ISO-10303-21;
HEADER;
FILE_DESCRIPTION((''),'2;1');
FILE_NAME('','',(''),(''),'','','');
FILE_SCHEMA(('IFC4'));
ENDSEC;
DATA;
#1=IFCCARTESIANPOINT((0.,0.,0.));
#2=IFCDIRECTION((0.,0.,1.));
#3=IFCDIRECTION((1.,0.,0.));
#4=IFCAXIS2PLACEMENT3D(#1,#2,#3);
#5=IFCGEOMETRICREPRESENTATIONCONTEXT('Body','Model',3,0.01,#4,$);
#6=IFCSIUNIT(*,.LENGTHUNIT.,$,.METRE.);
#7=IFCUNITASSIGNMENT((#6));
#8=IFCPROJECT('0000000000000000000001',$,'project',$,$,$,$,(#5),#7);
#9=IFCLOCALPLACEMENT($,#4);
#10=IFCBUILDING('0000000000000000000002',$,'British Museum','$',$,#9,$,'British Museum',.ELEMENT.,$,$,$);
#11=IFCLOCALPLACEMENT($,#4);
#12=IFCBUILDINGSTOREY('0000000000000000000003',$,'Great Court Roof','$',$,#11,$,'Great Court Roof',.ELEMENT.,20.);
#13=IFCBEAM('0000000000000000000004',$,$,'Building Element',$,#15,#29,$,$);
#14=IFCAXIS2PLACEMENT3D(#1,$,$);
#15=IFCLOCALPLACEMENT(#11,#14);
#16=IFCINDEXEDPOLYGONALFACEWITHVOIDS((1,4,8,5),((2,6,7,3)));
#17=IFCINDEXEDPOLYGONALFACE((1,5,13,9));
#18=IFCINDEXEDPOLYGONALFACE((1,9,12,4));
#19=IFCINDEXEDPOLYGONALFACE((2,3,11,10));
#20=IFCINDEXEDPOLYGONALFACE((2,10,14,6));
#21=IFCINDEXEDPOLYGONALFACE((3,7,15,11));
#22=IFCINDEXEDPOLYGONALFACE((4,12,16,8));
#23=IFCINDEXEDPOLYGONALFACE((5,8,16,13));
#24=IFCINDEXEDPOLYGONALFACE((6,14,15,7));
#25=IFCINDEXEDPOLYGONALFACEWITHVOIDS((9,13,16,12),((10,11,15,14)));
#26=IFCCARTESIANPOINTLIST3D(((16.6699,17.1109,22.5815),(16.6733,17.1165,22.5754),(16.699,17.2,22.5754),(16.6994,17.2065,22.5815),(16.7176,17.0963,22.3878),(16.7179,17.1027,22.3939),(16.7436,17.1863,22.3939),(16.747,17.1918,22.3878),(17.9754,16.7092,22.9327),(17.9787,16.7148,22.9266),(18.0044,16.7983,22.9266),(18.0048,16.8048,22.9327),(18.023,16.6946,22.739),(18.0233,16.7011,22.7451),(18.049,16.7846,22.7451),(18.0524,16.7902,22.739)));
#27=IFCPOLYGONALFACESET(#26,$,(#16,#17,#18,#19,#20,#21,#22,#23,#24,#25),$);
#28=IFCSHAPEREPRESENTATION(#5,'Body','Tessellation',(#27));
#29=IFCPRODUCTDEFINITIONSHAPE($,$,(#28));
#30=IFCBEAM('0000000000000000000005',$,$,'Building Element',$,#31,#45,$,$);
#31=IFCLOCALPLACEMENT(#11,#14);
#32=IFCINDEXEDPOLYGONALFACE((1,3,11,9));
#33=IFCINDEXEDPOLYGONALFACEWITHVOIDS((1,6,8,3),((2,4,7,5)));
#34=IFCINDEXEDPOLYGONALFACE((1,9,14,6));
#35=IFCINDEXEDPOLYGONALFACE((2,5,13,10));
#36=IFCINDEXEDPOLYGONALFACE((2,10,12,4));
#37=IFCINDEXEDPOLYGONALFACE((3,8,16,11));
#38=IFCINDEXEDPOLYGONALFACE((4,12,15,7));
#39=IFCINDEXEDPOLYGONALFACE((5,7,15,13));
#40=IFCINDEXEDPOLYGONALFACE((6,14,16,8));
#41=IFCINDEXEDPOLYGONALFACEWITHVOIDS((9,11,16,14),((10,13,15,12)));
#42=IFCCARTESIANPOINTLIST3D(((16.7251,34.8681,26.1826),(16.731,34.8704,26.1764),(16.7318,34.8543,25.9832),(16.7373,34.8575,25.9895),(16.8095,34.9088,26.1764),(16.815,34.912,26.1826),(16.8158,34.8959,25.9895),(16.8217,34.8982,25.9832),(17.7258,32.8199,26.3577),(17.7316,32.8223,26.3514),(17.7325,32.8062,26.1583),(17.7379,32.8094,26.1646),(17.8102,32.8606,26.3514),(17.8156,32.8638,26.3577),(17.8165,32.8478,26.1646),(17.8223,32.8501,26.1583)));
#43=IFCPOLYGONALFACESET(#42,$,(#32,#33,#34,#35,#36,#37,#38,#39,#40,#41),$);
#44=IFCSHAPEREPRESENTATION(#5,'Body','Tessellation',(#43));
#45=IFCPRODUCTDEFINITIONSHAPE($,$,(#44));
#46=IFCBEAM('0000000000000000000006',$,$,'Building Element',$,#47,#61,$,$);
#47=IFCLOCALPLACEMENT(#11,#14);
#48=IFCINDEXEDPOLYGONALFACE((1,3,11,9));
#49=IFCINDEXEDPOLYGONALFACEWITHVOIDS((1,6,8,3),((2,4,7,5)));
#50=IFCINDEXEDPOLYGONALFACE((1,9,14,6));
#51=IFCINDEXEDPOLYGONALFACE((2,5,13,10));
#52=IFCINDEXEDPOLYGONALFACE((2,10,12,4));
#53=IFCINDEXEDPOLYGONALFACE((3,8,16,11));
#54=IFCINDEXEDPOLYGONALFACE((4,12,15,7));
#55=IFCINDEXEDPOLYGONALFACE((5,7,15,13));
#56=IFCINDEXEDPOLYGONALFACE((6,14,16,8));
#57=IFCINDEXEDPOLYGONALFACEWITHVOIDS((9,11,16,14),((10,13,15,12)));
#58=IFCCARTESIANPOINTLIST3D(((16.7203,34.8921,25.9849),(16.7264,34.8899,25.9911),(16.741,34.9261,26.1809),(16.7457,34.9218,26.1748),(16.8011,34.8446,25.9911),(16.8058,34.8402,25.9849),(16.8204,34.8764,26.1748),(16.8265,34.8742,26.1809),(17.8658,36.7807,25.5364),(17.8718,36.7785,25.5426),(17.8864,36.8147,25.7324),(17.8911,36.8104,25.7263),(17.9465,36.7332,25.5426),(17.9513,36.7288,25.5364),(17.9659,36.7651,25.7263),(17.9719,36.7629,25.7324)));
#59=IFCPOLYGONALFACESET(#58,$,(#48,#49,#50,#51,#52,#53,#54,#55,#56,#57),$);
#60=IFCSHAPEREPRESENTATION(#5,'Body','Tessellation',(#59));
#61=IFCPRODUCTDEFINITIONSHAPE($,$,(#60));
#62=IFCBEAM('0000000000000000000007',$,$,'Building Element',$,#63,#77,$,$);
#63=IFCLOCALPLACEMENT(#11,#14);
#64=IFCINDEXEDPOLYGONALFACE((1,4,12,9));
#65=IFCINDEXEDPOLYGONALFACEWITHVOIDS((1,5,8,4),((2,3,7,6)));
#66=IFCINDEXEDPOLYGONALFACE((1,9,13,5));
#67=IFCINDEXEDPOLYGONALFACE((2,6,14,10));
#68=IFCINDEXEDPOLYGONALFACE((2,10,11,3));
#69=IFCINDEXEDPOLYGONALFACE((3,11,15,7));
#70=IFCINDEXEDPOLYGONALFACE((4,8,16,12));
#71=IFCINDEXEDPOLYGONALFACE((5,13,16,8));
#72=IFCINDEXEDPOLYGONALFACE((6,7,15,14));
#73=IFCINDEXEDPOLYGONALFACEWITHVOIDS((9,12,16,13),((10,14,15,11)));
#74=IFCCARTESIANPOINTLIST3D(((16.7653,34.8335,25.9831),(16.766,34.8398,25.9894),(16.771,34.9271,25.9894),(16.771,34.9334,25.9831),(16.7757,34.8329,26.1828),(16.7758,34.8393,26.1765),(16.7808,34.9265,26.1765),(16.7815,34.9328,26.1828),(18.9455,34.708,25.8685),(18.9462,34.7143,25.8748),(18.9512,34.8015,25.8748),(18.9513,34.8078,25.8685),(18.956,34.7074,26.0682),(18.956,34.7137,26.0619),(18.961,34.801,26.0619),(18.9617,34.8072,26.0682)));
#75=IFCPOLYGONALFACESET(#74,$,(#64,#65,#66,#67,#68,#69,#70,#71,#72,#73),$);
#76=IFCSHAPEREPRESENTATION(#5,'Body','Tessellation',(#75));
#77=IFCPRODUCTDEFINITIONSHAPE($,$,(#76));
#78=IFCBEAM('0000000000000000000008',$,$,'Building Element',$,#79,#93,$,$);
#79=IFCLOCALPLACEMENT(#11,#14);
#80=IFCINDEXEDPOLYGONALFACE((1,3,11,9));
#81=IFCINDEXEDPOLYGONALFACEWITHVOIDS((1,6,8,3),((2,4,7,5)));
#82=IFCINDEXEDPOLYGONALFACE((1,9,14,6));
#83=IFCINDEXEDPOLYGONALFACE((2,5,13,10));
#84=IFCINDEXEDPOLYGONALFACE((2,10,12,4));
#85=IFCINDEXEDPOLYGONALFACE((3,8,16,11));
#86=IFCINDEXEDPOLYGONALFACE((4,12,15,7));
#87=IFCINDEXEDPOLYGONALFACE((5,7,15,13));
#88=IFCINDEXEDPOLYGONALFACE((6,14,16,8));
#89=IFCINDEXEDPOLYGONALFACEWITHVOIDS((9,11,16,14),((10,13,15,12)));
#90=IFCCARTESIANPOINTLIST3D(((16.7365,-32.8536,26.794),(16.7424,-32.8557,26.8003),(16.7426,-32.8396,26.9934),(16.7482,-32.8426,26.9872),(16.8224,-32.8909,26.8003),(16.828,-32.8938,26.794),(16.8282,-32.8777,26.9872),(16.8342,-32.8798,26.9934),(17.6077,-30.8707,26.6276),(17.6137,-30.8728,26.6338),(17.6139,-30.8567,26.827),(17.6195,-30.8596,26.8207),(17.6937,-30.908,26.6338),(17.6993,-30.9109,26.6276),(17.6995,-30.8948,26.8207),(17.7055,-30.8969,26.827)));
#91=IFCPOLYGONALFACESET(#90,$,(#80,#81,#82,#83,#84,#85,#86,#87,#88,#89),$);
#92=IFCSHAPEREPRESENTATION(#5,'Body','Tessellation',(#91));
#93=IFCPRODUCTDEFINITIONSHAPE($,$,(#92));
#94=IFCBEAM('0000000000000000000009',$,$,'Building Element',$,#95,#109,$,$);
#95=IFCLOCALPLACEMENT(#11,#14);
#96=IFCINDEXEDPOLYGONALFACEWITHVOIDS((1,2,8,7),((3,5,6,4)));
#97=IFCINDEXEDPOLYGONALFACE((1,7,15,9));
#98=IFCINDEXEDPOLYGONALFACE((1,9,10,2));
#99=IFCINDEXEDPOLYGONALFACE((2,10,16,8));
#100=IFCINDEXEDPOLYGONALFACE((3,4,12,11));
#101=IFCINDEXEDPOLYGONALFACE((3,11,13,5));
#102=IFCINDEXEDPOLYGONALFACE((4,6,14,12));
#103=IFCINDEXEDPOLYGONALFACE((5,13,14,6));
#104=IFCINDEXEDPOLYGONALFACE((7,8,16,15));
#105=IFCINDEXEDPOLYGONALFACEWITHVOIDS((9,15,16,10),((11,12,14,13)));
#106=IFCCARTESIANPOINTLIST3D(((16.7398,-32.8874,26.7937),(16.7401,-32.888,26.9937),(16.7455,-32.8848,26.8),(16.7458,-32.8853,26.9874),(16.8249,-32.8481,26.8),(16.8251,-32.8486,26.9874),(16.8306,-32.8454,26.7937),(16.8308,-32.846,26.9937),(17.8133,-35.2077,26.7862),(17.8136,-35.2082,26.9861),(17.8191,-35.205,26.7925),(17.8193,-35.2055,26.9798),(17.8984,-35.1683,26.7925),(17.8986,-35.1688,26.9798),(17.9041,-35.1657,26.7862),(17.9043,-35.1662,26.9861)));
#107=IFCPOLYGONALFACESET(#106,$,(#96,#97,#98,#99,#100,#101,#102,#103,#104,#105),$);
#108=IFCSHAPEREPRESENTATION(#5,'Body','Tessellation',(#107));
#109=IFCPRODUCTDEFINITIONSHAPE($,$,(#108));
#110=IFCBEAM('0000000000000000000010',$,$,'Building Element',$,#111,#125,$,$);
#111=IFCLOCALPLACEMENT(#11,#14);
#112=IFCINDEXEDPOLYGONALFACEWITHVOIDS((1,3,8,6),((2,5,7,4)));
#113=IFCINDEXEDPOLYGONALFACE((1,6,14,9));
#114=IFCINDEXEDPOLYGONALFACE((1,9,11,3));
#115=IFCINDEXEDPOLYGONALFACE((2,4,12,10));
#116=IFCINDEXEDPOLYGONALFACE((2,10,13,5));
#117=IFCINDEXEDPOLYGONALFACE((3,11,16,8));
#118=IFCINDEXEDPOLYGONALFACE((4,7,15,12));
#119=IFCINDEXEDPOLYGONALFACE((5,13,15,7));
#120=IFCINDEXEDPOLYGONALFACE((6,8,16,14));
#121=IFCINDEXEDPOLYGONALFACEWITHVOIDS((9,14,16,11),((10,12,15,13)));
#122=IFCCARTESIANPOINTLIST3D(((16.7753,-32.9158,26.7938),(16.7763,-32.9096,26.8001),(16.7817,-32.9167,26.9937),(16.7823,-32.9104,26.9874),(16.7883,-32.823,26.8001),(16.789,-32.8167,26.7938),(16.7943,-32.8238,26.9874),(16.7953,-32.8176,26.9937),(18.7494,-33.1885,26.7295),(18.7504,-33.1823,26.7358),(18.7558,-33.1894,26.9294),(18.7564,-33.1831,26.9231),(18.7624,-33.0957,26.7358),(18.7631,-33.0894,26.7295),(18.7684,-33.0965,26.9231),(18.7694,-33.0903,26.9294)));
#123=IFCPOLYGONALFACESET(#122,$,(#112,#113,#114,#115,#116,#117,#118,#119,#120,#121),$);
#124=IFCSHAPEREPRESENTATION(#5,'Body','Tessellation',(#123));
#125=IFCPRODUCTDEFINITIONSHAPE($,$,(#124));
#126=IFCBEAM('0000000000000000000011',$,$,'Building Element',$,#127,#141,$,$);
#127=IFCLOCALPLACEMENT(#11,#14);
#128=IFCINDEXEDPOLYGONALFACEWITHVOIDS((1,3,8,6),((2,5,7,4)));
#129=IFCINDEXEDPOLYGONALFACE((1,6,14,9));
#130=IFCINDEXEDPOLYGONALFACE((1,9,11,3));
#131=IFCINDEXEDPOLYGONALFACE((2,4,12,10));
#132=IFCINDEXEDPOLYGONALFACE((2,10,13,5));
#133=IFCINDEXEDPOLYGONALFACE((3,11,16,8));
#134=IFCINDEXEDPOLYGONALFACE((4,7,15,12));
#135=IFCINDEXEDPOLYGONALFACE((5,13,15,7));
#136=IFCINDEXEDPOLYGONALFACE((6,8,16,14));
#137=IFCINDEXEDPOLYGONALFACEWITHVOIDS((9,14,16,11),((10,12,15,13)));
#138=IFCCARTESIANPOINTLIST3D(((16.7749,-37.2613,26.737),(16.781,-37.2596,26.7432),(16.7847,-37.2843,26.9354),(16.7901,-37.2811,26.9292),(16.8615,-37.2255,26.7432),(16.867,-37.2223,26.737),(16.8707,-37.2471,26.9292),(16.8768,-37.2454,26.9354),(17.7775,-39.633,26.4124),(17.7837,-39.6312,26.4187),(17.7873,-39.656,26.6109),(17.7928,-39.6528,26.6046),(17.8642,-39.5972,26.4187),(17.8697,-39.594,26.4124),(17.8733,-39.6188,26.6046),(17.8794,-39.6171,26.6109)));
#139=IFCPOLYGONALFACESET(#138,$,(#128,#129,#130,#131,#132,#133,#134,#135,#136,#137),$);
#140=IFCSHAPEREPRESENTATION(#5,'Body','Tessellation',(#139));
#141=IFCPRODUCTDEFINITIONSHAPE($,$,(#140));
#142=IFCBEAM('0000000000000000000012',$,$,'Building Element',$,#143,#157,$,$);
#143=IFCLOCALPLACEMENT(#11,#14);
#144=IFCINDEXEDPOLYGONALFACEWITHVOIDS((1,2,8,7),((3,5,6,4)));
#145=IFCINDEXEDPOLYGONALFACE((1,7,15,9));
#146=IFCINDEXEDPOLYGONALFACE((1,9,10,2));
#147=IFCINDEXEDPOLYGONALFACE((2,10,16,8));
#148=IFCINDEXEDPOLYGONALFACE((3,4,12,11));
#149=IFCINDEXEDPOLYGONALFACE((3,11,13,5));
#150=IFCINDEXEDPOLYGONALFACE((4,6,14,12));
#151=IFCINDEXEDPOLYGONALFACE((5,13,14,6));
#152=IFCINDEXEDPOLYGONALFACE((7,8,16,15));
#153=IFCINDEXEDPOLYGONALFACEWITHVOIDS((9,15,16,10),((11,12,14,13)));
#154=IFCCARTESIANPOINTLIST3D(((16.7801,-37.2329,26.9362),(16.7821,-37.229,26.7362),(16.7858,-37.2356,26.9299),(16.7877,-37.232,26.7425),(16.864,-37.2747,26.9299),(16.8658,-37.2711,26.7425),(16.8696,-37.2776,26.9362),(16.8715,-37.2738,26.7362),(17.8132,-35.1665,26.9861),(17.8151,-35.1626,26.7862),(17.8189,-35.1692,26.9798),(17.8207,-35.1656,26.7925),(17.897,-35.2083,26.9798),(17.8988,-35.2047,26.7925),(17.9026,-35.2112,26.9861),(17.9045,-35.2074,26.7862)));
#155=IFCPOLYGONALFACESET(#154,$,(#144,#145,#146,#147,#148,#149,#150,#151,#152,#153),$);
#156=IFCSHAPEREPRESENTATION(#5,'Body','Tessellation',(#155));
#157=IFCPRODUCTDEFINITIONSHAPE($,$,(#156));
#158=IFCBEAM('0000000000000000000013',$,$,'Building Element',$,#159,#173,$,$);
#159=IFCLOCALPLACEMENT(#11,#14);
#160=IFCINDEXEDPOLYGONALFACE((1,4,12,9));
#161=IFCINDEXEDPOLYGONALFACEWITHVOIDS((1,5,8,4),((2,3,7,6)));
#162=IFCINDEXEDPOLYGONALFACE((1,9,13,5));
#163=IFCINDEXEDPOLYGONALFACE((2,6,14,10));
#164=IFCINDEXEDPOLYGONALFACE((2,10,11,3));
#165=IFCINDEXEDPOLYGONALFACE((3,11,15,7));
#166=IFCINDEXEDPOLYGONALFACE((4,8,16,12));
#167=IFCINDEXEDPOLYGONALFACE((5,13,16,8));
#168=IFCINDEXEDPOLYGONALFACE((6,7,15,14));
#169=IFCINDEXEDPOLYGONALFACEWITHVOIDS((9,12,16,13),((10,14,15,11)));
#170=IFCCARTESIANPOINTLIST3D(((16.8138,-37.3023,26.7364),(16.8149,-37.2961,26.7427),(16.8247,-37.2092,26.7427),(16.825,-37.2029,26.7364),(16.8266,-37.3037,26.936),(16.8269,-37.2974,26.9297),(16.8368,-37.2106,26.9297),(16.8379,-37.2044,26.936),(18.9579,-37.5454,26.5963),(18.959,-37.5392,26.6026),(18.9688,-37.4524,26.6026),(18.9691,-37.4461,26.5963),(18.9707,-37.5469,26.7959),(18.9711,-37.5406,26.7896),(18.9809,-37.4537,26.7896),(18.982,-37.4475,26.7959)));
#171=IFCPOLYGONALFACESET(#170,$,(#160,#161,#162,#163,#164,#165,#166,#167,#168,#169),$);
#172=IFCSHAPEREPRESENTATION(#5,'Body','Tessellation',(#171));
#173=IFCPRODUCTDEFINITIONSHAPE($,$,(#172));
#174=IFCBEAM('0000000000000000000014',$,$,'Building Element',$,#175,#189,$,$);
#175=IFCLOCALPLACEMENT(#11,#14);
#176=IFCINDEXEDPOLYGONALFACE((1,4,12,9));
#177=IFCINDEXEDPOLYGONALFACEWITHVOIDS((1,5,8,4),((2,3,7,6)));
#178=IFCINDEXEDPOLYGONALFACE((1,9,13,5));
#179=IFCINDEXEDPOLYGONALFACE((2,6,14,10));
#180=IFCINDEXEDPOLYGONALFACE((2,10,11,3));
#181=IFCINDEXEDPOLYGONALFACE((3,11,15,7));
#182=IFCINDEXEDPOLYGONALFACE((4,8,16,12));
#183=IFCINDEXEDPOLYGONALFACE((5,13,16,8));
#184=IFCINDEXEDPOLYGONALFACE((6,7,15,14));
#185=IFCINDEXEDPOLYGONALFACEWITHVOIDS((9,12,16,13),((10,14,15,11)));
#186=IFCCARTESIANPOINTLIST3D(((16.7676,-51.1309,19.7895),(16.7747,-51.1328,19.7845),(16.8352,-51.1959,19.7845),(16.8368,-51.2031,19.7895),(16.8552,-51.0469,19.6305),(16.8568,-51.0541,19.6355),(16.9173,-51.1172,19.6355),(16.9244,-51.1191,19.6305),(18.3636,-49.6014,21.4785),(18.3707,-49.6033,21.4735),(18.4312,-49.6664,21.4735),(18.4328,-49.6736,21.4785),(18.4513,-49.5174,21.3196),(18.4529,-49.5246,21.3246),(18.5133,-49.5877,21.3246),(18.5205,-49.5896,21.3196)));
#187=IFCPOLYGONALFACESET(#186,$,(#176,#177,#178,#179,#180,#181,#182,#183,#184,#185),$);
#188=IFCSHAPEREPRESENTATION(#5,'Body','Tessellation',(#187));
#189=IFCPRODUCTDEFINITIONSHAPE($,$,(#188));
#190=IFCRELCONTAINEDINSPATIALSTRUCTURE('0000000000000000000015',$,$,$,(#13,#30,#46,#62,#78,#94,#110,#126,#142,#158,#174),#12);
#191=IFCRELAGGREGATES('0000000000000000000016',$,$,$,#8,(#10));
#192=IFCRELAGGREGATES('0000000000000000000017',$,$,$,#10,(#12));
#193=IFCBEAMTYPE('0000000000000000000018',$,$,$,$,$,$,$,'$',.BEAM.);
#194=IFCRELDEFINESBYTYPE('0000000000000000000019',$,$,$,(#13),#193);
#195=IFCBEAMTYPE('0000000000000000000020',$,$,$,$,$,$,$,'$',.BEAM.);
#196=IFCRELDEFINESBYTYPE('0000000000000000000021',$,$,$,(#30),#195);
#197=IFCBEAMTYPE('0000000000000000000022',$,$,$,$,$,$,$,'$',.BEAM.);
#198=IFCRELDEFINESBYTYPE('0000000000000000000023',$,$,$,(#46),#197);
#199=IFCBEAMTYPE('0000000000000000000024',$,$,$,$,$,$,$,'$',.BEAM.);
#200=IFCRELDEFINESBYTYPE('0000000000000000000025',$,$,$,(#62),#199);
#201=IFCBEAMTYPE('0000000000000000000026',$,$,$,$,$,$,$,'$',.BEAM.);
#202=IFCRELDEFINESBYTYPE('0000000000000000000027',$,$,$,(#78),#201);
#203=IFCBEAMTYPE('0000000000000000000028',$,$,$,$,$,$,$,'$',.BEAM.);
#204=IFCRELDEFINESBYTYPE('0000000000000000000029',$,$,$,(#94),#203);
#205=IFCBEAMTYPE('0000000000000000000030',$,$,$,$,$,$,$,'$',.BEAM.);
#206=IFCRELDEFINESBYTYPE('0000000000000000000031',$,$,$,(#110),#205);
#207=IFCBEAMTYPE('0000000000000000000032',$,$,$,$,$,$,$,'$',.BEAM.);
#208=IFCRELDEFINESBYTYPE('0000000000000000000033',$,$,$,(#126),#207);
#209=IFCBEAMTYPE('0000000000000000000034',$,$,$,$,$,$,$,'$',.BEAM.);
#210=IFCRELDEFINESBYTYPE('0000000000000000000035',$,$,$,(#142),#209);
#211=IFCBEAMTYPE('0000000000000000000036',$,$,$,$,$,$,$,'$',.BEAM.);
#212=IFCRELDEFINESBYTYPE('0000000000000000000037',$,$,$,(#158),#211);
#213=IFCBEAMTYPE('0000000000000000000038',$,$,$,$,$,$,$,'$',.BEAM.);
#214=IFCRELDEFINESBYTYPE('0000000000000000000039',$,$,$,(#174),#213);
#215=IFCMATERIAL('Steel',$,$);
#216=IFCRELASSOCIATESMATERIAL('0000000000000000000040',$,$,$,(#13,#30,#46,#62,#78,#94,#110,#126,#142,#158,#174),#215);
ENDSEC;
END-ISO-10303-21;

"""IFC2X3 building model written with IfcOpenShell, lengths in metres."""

from ifc_helpers import new_model, si_unit, frame, origin_with_axes, origin_2d, place, context, project, spatial, hollow_rectangle, extrude, material, type_object, element, save


model = new_model("IFC2X3")

# Units and contexts
model_context = context("Model", 3, precision=0.01, world=origin_with_axes(), identifier="Body")
ifc_project = project(units=[si_unit("LENGTHUNIT", "METRE")], contexts=[model_context])

# Building, storey
building_placement = place(None, origin_with_axes())
building = spatial("IfcBuilding", under=ifc_project, at=building_placement, Name="British Museum", Description="$", LongName="British Museum", CompositionType="ELEMENT")
storey_placement = place(None, origin_with_axes())
storey = spatial("IfcBuildingStorey", under=building, at=storey_placement, Name="Great Court Roof", Description="$", LongName="Great Court Roof", CompositionType="ELEMENT", Elevation=20.0)

# Beams
ifc_material = material(Name="Steel")
beam_type_1 = type_object("IfcBeamType", ElementType="$", PredefinedType="BEAM")
beam_1_placement = place(None, origin_with_axes())
element("IfcBeam", 1, at=beam_1_placement, inside=storey, type_object=beam_type_1, material=ifc_material, Description="Building Element", context=model_context, shape_type="SweptSolid", body=[
    extrude(hollow_rectangle(XDim=0.1, YDim=0.2, WallThickness=0.0063, InnerFilletRadius=-0.0063, OuterFilletRadius=0.0, at=origin_2d()), frame((16.7085, 17.1514, 22.4846), z_axis=(0.925668, -0.284824, 0.249025), x_axis=(0.294088, 0.955778, 0.0)), (0.0, 0.0, 1.0), 1.4103),
])
beam_type_2 = type_object("IfcBeamType", ElementType="$", PredefinedType="BEAM")
beam_2_placement = place(None, origin_with_axes())
element("IfcBeam", 2, at=beam_2_placement, inside=storey, type_object=beam_type_2, material=ifc_material, Description="Building Element", context=model_context, shape_type="SweptSolid", body=[
    extrude(hollow_rectangle(XDim=0.1, YDim=0.2, WallThickness=0.0063, InnerFilletRadius=-0.0063, OuterFilletRadius=0.0, at=origin_2d()), frame((16.7734, 34.8832, 26.0829), z_axis=(0.437693, -0.895858, 0.076573), x_axis=(0.898496, 0.438982, 0.0)), (0.0, 0.0, 1.0), 2.2862),
])
beam_type_3 = type_object("IfcBeamType", ElementType="$", PredefinedType="BEAM")
beam_3_placement = place(None, origin_with_axes())
element("IfcBeam", 3, at=beam_3_placement, inside=storey, type_object=beam_type_3, material=ifc_material, Description="Building Element", context=model_context, shape_type="SweptSolid", body=[
    extrude(hollow_rectangle(XDim=0.1, YDim=0.2, WallThickness=0.0063, InnerFilletRadius=-0.0063, OuterFilletRadius=0.0, at=origin_2d()), frame((16.7734, 34.8832, 26.0829), z_axis=(0.508208, 0.837933, -0.198982), x_axis=(-0.855031, 0.518578, 0.0)), (0.0, 0.0, 1.0), 2.2539),
])
beam_type_4 = type_object("IfcBeamType", ElementType="$", PredefinedType="BEAM")
beam_4_placement = place(None, origin_with_axes())
element("IfcBeam", 4, at=beam_4_placement, inside=storey, type_object=beam_type_4, material=ifc_material, Description="Building Element", context=model_context, shape_type="SweptSolid", body=[
    extrude(hollow_rectangle(XDim=0.1, YDim=0.2, WallThickness=0.0063, InnerFilletRadius=-0.0063, OuterFilletRadius=0.0, at=origin_2d()), frame((16.7734, 34.8832, 26.0829), z_axis=(0.996975, -0.057408, -0.052403), x_axis=(0.057487, 0.998346, 0.0)), (0.0, 0.0, 1.0), 2.1868),
])
beam_type_5 = type_object("IfcBeamType", ElementType="$", PredefinedType="BEAM")
beam_5_placement = place(None, origin_with_axes())
element("IfcBeam", 5, at=beam_5_placement, inside=storey, type_object=beam_type_5, material=ifc_material, Description="Building Element", context=model_context, shape_type="SweptSolid", body=[
    extrude(hollow_rectangle(XDim=0.1, YDim=0.2, WallThickness=0.0063, InnerFilletRadius=-0.0063, OuterFilletRadius=0.0, at=origin_2d()), frame((16.7853, -32.8667, 26.8937), z_axis=(0.401094, 0.912825, -0.076635), x_axis=(-0.915518, 0.402277, 0.0)), (0.0, 0.0, 1.0), 2.1723),
])
beam_type_6 = type_object("IfcBeamType", ElementType="$", PredefinedType="BEAM")
beam_6_placement = place(None, origin_with_axes())
element("IfcBeam", 6, at=beam_6_placement, inside=storey, type_object=beam_type_6, material=ifc_material, Description="Building Element", context=model_context, shape_type="SweptSolid", body=[
    extrude(hollow_rectangle(XDim=0.1, YDim=0.2, WallThickness=0.0063, InnerFilletRadius=-0.0063, OuterFilletRadius=0.0, at=origin_2d()), frame((16.7853, -32.8667, 26.8937), z_axis=(0.419916, -0.907558, -0.002966), x_axis=(0.907562, 0.419918, 0.0)), (0.0, 0.0, 1.0), 2.5565),
])
beam_type_7 = type_object("IfcBeamType", ElementType="$", PredefinedType="BEAM")
beam_7_placement = place(None, origin_with_axes())
element("IfcBeam", 7, at=beam_7_placement, inside=storey, type_object=beam_type_7, material=ifc_material, Description="Building Element", context=model_context, shape_type="SweptSolid", body=[
    extrude(hollow_rectangle(XDim=0.1, YDim=0.2, WallThickness=0.0063, InnerFilletRadius=-0.0063, OuterFilletRadius=0.0, at=origin_2d()), frame((16.7853, -32.8667, 26.8937), z_axis=(0.99008, -0.136758, -0.032229), x_axis=(0.136829, 0.990595, 0.0)), (0.0, 0.0, 1.0), 1.9939),
])
beam_type_8 = type_object("IfcBeamType", ElementType="$", PredefinedType="BEAM")
beam_8_placement = place(None, origin_with_axes())
element("IfcBeam", 8, at=beam_8_placement, inside=storey, type_object=beam_type_8, material=ifc_material, Description="Building Element", context=model_context, shape_type="SweptSolid", body=[
    extrude(hollow_rectangle(XDim=0.1, YDim=0.2, WallThickness=0.0063, InnerFilletRadius=-0.0063, OuterFilletRadius=0.0, at=origin_2d()), frame((16.8258, -37.2533, 26.8362), z_axis=(0.386328, -0.913845, -0.125048), x_axis=(0.921075, 0.389385, 0.0)), (0.0, 0.0, 1.0), 2.5953),
])
beam_type_9 = type_object("IfcBeamType", ElementType="$", PredefinedType="BEAM")
beam_9_placement = place(None, origin_with_axes())
element("IfcBeam", 9, at=beam_9_placement, inside=storey, type_object=beam_type_9, material=ifc_material, Description="Building Element", context=model_context, shape_type="SweptSolid", body=[
    extrude(hollow_rectangle(XDim=0.1, YDim=0.2, WallThickness=0.0063, InnerFilletRadius=-0.0063, OuterFilletRadius=0.0, at=origin_2d()), frame((16.8258, -37.2533, 26.8362), z_axis=(0.447042, 0.894252, 0.021619), x_axis=(-0.894461, 0.447146, 0.0)), (0.0, 0.0, 1.0), 2.3108),
])
beam_type_10 = type_object("IfcBeamType", ElementType="$", PredefinedType="BEAM")
beam_10_placement = place(None, origin_with_axes())
element("IfcBeam", 10, at=beam_10_placement, inside=storey, type_object=beam_type_10, material=ifc_material, Description="Building Element", context=model_context, shape_type="SweptSolid", body=[
    extrude(hollow_rectangle(XDim=0.1, YDim=0.2, WallThickness=0.0063, InnerFilletRadius=-0.0063, OuterFilletRadius=0.0, at=origin_2d()), frame((16.8258, -37.2533, 26.8362), z_axis=(0.991543, -0.112443, -0.064802), x_axis=(0.112679, 0.993631, 0.0)), (0.0, 0.0, 1.0), 2.1624),
])
beam_type_11 = type_object("IfcBeamType", ElementType="$", PredefinedType="BEAM")
beam_11_placement = place(None, origin_with_axes())
element("IfcBeam", 11, at=beam_11_placement, inside=storey, type_object=beam_type_11, material=ifc_material, Description="Building Element", context=model_context, shape_type="SweptSolid", body=[
    extrude(hollow_rectangle(XDim=0.1, YDim=0.2, WallThickness=0.0063, InnerFilletRadius=-0.0063, OuterFilletRadius=0.0, at=origin_2d()), frame((16.846, -51.125, 19.71), z_axis=(0.573693, 0.549776, 0.607143), x_axis=(-0.691897, 0.721996, 0.0)), (0.0, 0.0, 1.0), 2.782),
])

save(model, "model.ifc")
